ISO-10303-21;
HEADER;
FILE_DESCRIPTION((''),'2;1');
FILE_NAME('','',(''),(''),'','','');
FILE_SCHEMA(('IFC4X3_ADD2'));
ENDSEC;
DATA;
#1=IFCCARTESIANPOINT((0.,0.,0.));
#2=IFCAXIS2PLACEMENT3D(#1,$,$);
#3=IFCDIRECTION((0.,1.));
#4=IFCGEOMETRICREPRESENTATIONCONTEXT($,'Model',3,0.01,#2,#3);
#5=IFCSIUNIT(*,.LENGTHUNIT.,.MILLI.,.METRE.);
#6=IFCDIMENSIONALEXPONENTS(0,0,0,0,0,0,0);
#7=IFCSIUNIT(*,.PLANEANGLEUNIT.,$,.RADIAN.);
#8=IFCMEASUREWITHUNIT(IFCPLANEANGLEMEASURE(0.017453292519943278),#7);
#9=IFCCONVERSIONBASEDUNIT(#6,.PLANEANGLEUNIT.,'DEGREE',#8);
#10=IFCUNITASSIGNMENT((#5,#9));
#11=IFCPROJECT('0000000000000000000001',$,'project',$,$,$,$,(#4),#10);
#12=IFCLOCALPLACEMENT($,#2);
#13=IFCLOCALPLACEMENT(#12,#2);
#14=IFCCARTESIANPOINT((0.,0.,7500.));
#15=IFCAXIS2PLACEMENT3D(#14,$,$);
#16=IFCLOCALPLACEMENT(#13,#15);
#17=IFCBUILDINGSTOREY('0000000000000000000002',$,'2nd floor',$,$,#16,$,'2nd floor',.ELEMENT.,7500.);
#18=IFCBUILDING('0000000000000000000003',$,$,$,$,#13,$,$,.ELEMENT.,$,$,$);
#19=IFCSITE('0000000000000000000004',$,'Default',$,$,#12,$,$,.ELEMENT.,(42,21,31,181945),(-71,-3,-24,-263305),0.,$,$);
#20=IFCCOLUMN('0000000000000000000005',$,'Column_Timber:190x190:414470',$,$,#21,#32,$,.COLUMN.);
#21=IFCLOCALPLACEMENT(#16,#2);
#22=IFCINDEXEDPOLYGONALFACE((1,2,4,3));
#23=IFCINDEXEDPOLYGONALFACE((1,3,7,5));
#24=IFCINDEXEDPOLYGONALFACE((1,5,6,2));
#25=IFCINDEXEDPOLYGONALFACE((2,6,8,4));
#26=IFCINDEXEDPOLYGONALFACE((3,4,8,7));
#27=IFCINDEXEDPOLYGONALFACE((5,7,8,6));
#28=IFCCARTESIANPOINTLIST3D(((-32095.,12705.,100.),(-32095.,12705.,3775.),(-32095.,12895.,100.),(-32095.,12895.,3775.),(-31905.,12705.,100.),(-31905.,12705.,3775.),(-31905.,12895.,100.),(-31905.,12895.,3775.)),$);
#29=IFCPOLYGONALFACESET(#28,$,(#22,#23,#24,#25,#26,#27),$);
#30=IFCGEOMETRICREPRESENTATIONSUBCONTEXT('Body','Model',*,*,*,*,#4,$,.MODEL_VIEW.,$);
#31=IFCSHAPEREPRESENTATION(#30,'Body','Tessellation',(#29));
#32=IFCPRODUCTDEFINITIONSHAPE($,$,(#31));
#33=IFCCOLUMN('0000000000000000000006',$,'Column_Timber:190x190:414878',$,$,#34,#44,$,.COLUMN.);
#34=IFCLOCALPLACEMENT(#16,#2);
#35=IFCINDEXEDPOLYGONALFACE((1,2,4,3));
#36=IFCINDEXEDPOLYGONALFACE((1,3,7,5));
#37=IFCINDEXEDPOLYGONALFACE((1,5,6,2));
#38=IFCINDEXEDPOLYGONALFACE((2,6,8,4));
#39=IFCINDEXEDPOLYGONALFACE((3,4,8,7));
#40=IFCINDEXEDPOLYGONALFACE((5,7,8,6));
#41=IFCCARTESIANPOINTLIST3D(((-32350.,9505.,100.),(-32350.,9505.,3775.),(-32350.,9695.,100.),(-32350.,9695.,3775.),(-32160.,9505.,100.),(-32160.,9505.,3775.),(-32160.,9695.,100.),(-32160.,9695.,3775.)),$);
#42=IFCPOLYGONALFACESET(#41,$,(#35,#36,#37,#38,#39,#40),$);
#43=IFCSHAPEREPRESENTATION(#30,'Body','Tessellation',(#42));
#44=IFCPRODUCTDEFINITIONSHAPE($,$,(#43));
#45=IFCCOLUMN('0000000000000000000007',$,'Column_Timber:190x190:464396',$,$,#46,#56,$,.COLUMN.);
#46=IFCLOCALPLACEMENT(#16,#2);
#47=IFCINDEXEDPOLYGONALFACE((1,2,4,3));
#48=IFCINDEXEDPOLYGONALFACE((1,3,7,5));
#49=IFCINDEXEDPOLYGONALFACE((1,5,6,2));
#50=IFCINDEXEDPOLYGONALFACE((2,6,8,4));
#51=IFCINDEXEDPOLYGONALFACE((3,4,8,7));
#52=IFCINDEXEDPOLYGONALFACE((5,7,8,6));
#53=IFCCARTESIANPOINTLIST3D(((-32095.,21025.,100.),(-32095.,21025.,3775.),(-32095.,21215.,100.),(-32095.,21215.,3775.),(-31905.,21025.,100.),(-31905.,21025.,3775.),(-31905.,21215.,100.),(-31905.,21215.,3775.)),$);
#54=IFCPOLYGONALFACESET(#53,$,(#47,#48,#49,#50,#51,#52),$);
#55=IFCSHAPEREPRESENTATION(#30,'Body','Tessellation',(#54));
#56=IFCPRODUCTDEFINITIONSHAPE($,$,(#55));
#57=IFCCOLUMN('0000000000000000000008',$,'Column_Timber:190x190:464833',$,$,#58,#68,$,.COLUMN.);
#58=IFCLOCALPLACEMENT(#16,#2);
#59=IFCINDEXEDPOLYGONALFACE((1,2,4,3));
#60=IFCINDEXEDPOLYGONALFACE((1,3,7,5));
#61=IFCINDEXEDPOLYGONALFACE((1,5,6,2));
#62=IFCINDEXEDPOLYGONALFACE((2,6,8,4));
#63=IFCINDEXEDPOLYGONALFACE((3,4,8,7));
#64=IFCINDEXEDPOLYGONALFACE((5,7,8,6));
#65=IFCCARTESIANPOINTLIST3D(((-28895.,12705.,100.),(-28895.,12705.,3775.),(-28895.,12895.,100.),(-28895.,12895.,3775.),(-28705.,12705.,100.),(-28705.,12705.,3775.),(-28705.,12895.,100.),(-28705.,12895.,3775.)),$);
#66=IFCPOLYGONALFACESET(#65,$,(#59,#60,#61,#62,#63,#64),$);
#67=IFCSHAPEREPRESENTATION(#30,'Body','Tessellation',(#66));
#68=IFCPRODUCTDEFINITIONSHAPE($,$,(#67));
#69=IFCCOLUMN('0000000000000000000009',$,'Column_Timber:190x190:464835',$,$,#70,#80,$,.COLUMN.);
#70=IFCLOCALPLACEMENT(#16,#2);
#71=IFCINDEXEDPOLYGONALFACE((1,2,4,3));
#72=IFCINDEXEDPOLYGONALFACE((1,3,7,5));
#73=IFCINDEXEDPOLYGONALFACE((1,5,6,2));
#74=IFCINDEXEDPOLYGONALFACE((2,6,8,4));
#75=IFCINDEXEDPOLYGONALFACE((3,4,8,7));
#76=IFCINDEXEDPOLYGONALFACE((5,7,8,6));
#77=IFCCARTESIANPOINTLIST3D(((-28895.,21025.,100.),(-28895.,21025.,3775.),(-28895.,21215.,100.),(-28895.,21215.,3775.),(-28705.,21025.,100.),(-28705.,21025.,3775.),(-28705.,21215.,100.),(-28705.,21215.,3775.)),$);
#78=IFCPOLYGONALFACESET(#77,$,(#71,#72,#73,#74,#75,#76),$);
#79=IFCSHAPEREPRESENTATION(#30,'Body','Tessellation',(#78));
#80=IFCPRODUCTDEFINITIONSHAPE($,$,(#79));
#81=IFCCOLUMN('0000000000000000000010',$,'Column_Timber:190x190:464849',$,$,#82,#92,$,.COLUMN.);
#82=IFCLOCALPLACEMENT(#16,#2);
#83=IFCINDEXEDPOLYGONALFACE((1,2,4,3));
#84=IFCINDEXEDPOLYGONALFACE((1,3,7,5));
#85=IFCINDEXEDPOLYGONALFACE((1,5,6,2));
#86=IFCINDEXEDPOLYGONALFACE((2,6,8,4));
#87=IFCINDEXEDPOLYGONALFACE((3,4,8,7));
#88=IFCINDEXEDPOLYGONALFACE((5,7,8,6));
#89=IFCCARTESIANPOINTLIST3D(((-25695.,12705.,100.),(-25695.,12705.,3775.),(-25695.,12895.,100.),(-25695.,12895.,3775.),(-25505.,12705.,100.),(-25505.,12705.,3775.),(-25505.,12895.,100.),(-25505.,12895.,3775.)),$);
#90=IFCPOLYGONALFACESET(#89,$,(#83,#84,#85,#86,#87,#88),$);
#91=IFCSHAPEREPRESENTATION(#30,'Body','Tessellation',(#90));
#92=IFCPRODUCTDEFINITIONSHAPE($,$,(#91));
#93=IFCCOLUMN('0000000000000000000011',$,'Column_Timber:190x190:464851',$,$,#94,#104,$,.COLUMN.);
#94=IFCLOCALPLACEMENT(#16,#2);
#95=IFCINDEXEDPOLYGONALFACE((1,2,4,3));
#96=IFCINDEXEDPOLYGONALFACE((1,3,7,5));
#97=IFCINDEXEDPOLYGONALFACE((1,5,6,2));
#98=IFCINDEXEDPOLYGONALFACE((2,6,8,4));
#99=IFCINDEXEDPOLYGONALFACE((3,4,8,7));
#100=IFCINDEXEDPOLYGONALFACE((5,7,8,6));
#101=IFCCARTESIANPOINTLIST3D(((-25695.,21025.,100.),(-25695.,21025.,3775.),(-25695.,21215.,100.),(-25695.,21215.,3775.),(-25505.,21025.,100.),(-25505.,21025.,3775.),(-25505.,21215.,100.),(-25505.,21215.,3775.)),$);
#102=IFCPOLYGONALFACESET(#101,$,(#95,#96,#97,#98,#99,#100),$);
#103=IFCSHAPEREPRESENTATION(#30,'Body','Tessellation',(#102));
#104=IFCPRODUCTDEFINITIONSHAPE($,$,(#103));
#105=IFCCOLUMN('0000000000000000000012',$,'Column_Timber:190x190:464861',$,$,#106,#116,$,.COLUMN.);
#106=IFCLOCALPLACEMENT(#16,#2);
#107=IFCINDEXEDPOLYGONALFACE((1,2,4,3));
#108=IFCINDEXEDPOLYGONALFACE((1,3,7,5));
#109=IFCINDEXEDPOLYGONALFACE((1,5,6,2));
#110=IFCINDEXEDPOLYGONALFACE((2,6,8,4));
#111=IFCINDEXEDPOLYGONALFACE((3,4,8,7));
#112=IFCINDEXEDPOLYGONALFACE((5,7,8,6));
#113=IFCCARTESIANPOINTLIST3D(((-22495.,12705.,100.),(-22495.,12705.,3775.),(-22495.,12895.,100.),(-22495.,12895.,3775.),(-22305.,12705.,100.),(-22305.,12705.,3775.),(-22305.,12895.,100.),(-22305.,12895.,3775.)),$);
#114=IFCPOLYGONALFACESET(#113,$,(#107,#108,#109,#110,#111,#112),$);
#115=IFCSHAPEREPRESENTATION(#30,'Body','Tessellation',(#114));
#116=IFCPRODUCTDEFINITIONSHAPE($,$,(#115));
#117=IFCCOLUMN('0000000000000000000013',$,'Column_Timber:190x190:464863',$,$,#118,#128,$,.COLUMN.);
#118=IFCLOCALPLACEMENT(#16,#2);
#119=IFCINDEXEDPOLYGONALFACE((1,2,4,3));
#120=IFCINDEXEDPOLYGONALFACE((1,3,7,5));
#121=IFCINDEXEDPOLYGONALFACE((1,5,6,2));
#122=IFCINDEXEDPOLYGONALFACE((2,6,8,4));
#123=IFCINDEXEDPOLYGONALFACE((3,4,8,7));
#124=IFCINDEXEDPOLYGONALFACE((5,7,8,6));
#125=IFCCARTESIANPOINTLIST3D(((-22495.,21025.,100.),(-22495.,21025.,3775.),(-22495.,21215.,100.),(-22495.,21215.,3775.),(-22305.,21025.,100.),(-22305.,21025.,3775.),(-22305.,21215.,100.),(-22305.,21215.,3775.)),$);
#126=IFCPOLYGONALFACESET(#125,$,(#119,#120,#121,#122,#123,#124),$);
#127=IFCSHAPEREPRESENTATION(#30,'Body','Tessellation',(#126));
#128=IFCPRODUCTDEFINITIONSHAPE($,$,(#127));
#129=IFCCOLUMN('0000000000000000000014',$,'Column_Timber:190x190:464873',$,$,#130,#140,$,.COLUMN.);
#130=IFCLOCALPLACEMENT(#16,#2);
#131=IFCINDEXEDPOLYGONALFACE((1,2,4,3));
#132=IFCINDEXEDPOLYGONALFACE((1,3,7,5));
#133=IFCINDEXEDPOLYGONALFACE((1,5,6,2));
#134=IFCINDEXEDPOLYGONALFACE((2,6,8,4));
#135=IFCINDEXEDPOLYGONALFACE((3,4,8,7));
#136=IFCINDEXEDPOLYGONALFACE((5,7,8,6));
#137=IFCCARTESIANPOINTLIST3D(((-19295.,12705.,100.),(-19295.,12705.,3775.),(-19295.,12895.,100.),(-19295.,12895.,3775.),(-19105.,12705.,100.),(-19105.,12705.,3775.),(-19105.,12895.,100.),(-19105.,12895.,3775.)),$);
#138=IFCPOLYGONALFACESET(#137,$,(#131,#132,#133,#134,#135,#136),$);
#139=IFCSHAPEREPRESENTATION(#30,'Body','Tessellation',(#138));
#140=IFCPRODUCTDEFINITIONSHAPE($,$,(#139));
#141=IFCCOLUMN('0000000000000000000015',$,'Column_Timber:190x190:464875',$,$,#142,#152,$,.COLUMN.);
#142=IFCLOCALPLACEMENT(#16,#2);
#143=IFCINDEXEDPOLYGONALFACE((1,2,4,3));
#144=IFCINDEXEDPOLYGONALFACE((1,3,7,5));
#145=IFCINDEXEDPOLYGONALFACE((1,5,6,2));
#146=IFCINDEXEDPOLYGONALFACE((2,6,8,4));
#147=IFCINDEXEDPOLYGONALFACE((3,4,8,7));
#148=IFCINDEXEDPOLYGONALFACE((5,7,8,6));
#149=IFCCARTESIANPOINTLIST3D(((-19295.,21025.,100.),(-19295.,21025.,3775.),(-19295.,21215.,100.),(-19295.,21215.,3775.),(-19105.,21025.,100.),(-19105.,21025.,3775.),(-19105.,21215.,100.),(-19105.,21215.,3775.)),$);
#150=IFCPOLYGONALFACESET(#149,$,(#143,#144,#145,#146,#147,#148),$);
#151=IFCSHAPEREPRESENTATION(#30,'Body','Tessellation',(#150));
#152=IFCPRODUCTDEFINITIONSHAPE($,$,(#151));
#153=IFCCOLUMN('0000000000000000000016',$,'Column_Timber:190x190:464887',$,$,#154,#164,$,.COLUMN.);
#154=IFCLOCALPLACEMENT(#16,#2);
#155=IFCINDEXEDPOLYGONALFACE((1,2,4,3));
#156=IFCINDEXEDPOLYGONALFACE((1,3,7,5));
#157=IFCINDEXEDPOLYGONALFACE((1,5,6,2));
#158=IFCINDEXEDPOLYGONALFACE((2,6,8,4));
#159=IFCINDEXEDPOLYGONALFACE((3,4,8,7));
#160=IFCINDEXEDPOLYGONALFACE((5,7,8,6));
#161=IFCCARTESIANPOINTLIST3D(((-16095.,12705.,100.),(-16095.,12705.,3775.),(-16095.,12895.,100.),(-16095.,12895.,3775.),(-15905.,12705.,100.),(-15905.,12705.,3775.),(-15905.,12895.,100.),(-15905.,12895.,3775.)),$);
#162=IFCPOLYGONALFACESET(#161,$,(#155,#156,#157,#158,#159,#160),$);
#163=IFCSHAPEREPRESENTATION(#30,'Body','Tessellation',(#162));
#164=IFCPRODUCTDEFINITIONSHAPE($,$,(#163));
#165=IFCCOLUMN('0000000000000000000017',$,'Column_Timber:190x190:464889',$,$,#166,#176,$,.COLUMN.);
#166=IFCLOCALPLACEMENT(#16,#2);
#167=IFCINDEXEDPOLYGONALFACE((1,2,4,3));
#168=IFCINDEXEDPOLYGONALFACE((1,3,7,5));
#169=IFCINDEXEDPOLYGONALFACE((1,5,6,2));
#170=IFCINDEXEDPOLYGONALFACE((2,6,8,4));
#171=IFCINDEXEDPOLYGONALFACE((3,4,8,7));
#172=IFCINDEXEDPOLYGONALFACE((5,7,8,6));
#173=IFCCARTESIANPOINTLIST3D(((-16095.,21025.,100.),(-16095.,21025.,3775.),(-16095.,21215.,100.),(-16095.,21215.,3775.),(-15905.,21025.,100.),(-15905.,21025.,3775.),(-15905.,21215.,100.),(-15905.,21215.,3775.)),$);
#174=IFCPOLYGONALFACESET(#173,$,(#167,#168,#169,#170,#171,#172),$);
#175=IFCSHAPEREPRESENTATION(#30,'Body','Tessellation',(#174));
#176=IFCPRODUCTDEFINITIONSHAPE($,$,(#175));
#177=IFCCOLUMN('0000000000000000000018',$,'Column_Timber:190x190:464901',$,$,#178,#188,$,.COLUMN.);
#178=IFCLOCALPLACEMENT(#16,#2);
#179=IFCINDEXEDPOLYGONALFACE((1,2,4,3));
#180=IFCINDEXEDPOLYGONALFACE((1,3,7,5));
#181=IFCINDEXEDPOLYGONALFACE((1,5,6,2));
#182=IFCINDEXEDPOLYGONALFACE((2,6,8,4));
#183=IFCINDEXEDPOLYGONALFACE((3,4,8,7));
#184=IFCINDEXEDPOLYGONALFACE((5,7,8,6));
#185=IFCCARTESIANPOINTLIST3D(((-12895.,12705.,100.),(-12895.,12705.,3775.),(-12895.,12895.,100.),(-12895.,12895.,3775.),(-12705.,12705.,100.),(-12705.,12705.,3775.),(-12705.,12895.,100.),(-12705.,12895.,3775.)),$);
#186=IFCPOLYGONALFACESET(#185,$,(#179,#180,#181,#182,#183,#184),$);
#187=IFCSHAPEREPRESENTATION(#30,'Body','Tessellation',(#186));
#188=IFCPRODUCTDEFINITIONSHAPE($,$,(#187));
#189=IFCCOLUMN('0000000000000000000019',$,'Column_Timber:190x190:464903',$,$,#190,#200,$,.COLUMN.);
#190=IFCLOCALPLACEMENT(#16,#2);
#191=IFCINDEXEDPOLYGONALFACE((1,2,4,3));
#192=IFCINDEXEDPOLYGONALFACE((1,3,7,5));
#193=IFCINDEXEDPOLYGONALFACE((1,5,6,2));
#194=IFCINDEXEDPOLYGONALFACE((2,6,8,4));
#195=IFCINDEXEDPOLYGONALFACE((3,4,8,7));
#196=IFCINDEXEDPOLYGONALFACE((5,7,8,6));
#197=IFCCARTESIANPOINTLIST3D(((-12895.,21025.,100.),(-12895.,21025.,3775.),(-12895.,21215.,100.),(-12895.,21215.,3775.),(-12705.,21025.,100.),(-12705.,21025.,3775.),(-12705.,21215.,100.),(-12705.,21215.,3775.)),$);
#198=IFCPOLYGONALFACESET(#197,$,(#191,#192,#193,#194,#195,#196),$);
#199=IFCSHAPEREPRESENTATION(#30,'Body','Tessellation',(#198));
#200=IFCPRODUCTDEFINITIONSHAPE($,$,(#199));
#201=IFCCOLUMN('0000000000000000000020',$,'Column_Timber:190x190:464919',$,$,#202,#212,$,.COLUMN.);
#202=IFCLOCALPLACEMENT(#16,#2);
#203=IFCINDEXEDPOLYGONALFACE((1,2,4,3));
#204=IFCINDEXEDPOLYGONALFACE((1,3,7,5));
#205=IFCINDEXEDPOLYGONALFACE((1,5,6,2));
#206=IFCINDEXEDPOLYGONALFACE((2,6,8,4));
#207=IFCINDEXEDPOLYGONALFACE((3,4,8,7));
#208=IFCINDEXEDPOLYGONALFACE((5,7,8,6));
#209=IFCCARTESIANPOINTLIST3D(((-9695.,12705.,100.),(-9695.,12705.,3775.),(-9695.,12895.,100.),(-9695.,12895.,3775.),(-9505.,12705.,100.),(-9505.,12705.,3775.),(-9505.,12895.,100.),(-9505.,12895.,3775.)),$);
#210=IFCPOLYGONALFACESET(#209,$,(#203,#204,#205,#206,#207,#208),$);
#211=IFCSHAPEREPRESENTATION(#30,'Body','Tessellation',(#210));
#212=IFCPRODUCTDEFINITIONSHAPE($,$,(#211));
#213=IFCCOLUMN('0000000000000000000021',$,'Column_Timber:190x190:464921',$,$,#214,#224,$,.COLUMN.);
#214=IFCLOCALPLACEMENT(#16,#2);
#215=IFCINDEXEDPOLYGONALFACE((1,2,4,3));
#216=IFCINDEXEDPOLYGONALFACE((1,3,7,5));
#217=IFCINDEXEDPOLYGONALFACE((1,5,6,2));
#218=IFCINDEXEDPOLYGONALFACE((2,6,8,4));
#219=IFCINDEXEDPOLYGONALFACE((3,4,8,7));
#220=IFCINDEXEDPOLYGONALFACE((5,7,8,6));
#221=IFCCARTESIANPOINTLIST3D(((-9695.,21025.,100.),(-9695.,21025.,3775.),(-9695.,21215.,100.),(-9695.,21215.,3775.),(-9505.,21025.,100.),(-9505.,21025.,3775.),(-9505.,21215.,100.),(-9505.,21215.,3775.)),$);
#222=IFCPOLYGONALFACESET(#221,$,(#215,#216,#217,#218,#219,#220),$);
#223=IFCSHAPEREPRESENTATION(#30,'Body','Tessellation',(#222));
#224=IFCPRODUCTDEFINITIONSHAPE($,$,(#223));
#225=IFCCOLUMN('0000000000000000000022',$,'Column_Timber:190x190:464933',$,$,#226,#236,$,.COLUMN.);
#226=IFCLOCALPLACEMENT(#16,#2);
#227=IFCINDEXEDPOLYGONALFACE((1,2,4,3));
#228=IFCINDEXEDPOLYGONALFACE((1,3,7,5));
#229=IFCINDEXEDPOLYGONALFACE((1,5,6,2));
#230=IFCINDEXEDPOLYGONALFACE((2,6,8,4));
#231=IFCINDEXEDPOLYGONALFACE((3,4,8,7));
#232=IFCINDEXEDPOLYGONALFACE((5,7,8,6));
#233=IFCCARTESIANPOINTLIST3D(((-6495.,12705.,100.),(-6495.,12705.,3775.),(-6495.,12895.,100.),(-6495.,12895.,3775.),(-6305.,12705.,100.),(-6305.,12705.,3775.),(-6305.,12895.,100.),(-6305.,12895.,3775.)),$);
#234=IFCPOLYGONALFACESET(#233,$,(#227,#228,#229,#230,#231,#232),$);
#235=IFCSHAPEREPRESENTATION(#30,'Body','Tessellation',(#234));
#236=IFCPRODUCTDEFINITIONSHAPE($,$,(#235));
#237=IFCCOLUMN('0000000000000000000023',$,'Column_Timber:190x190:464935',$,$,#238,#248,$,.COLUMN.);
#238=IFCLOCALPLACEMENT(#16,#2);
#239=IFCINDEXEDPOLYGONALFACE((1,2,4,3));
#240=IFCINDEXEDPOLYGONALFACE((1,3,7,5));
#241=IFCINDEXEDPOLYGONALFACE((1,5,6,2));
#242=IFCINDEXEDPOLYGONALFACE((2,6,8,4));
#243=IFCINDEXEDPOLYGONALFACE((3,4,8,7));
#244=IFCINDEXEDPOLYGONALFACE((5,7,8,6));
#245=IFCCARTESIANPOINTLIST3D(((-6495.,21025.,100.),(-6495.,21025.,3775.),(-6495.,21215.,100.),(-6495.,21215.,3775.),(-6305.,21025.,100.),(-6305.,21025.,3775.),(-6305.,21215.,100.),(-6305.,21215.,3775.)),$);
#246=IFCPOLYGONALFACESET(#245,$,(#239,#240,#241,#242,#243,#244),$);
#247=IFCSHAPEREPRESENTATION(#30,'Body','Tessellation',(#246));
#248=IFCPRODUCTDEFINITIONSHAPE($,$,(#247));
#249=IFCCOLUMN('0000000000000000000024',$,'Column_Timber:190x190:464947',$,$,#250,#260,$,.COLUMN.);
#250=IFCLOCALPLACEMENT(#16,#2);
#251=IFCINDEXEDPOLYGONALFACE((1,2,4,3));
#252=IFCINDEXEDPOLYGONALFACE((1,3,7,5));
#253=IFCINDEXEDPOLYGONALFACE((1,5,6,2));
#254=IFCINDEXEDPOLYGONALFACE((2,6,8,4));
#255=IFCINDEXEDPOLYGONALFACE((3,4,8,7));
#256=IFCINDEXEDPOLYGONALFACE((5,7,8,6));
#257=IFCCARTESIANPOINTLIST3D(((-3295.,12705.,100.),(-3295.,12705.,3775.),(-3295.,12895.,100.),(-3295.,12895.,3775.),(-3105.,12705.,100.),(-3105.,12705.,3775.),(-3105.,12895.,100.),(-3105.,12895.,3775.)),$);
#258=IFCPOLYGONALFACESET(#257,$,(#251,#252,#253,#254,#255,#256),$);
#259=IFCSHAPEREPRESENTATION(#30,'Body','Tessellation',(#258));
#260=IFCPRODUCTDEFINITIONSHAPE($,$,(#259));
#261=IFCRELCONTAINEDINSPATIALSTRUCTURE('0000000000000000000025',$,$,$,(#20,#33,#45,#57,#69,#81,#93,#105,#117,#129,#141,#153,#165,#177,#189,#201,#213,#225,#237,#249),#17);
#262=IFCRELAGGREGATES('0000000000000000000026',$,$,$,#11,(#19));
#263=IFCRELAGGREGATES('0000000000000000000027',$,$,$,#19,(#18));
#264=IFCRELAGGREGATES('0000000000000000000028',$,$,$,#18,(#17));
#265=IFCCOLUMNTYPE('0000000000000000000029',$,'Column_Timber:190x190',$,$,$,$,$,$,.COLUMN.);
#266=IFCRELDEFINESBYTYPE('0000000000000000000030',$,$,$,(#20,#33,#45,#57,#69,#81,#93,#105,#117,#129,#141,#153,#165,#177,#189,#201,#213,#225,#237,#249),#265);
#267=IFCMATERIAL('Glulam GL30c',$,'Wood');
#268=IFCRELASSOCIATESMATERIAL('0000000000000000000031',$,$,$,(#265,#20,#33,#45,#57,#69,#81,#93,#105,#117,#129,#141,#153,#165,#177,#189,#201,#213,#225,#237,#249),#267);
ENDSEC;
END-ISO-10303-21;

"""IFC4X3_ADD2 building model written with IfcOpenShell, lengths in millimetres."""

from ifc_helpers import new_model, entity, si_unit, converted_unit, direction, frame, origin, origin_2d_with_axis, place, context, subcontext, project, spatial, rectangle, extrude, source, transform, mapped, material, material_profile, profile_set, profile_usage, type_object, type_shapes, element, save


model = new_model("IFC4X3_ADD2")

# Units and contexts
model_context = context("Model", 3, precision=0.01, world=origin(), true_north=direction((0.0, 1.0)))
body_context = subcontext(model_context, "Body", "Model", "MODEL_VIEW")
ifc_project = project(units=[si_unit("LENGTHUNIT", "METRE", prefix="MILLI"), converted_unit("PLANEANGLEUNIT", "DEGREE", entity("IfcPlaneAngleMeasure", 0.017453292519943278), si_unit("PLANEANGLEUNIT", "RADIAN"), dimensions=[0, 0, 0, 0, 0, 0, 0])], contexts=[model_context])

# Site, building, storey
site_placement = place(None, origin())
site = spatial("IfcSite", under=ifc_project, at=site_placement, Name="Default", CompositionType="ELEMENT", RefLatitude=(42, 21, 31, 181945), RefLongitude=(-71, -3, -24, -263305), RefElevation=0.0)
building_placement = place(site_placement, origin())
building = spatial("IfcBuilding", under=site, at=building_placement, CompositionType="ELEMENT")
storey_placement = place(building_placement, frame((0.0, 0.0, 7500.0)))
storey = spatial("IfcBuildingStorey", under=building, at=storey_placement, Name="2nd floor", LongName="2nd floor", CompositionType="ELEMENT", Elevation=7500.0)

# Columns
ifc_material_1 = material(Name="Glulam GL30c", Category="Wood")
ifc_material_profile_1 = material_profile(ifc_material_1, rectangle(XDim=190.0, YDim=190.0, at=origin_2d_with_axis()), Name="190x190")
ifc_profile_set_1 = profile_set([ifc_material_profile_1], Name="190x190")
ifc_profile_usage_1 = profile_usage(ifc_profile_set_1)
column_type = type_object("IfcColumnType", Name="Column_Timber:190x190", PredefinedType="COLUMN", material=ifc_profile_set_1)
shared_shape_1 = source(origin(), body_context, "Body", "SweptSolid", [
    extrude(rectangle(XDim=190.0, YDim=190.0, at=origin_2d_with_axis()), frame((0.0, 0.0, 7600.0), z_axis=(0.0, 0.0, 1.0), x_axis=(-1.0, 0.0, 0.0)), (0.0, 0.0, 1.0), 3675.0),
])
type_shapes(column_type, [shared_shape_1])
for number, where, name in (
    (1, (-32000.0, 12800.0, -7500.0), "Column_Timber:190x190:414470"),
    (2, (-32255.0, 9600.0, -7500.0), "Column_Timber:190x190:414878"),
    (3, (-32000.0, 21120.0, -7500.0), "Column_Timber:190x190:464396"),
    (4, (-28800.0, 12800.0, -7500.0), "Column_Timber:190x190:464833"),
    (5, (-28800.0, 21120.0, -7500.0), "Column_Timber:190x190:464835"),
    (6, (-25600.0, 12800.0, -7500.0), "Column_Timber:190x190:464849"),
    (7, (-25600.0, 21120.0, -7500.0), "Column_Timber:190x190:464851"),
    (8, (-22400.0, 12800.0, -7500.0), "Column_Timber:190x190:464861"),
    (9, (-22400.0, 21120.0, -7500.0), "Column_Timber:190x190:464863"),
    (10, (-19200.0, 12800.0, -7500.0), "Column_Timber:190x190:464873"),
    (11, (-19200.0, 21120.0, -7500.0), "Column_Timber:190x190:464875"),
    (12, (-16000.0, 12800.0, -7500.0), "Column_Timber:190x190:464887"),
    (13, (-16000.0, 21120.0, -7500.0), "Column_Timber:190x190:464889"),
    (14, (-12800.0, 12800.0, -7500.0), "Column_Timber:190x190:464901"),
    (15, (-12800.0, 21120.0, -7500.0), "Column_Timber:190x190:464903"),
    (16, (-9600.0, 12800.0, -7500.0), "Column_Timber:190x190:464919"),
    (17, (-9600.0, 21120.0, -7500.0), "Column_Timber:190x190:464921"),
    (18, (-6400.0, 12800.0, -7500.0), "Column_Timber:190x190:464933"),
    (19, (-6400.0, 21120.0, -7500.0), "Column_Timber:190x190:464935"),
    (20, (-3200.0, 12800.0, -7500.0), "Column_Timber:190x190:464947"),
):
    element("IfcColumn", number, at=place(storey_placement, frame(where)), inside=storey, type_object=column_type, material=ifc_profile_usage_1, Name=name, PredefinedType="COLUMN", context=body_context, shape_type="MappedRepresentation", body=[
        mapped(shared_shape_1, transform((0.0, 0.0, 0.0), scale=1.0)),
    ])

save(model, "model.ifc")
